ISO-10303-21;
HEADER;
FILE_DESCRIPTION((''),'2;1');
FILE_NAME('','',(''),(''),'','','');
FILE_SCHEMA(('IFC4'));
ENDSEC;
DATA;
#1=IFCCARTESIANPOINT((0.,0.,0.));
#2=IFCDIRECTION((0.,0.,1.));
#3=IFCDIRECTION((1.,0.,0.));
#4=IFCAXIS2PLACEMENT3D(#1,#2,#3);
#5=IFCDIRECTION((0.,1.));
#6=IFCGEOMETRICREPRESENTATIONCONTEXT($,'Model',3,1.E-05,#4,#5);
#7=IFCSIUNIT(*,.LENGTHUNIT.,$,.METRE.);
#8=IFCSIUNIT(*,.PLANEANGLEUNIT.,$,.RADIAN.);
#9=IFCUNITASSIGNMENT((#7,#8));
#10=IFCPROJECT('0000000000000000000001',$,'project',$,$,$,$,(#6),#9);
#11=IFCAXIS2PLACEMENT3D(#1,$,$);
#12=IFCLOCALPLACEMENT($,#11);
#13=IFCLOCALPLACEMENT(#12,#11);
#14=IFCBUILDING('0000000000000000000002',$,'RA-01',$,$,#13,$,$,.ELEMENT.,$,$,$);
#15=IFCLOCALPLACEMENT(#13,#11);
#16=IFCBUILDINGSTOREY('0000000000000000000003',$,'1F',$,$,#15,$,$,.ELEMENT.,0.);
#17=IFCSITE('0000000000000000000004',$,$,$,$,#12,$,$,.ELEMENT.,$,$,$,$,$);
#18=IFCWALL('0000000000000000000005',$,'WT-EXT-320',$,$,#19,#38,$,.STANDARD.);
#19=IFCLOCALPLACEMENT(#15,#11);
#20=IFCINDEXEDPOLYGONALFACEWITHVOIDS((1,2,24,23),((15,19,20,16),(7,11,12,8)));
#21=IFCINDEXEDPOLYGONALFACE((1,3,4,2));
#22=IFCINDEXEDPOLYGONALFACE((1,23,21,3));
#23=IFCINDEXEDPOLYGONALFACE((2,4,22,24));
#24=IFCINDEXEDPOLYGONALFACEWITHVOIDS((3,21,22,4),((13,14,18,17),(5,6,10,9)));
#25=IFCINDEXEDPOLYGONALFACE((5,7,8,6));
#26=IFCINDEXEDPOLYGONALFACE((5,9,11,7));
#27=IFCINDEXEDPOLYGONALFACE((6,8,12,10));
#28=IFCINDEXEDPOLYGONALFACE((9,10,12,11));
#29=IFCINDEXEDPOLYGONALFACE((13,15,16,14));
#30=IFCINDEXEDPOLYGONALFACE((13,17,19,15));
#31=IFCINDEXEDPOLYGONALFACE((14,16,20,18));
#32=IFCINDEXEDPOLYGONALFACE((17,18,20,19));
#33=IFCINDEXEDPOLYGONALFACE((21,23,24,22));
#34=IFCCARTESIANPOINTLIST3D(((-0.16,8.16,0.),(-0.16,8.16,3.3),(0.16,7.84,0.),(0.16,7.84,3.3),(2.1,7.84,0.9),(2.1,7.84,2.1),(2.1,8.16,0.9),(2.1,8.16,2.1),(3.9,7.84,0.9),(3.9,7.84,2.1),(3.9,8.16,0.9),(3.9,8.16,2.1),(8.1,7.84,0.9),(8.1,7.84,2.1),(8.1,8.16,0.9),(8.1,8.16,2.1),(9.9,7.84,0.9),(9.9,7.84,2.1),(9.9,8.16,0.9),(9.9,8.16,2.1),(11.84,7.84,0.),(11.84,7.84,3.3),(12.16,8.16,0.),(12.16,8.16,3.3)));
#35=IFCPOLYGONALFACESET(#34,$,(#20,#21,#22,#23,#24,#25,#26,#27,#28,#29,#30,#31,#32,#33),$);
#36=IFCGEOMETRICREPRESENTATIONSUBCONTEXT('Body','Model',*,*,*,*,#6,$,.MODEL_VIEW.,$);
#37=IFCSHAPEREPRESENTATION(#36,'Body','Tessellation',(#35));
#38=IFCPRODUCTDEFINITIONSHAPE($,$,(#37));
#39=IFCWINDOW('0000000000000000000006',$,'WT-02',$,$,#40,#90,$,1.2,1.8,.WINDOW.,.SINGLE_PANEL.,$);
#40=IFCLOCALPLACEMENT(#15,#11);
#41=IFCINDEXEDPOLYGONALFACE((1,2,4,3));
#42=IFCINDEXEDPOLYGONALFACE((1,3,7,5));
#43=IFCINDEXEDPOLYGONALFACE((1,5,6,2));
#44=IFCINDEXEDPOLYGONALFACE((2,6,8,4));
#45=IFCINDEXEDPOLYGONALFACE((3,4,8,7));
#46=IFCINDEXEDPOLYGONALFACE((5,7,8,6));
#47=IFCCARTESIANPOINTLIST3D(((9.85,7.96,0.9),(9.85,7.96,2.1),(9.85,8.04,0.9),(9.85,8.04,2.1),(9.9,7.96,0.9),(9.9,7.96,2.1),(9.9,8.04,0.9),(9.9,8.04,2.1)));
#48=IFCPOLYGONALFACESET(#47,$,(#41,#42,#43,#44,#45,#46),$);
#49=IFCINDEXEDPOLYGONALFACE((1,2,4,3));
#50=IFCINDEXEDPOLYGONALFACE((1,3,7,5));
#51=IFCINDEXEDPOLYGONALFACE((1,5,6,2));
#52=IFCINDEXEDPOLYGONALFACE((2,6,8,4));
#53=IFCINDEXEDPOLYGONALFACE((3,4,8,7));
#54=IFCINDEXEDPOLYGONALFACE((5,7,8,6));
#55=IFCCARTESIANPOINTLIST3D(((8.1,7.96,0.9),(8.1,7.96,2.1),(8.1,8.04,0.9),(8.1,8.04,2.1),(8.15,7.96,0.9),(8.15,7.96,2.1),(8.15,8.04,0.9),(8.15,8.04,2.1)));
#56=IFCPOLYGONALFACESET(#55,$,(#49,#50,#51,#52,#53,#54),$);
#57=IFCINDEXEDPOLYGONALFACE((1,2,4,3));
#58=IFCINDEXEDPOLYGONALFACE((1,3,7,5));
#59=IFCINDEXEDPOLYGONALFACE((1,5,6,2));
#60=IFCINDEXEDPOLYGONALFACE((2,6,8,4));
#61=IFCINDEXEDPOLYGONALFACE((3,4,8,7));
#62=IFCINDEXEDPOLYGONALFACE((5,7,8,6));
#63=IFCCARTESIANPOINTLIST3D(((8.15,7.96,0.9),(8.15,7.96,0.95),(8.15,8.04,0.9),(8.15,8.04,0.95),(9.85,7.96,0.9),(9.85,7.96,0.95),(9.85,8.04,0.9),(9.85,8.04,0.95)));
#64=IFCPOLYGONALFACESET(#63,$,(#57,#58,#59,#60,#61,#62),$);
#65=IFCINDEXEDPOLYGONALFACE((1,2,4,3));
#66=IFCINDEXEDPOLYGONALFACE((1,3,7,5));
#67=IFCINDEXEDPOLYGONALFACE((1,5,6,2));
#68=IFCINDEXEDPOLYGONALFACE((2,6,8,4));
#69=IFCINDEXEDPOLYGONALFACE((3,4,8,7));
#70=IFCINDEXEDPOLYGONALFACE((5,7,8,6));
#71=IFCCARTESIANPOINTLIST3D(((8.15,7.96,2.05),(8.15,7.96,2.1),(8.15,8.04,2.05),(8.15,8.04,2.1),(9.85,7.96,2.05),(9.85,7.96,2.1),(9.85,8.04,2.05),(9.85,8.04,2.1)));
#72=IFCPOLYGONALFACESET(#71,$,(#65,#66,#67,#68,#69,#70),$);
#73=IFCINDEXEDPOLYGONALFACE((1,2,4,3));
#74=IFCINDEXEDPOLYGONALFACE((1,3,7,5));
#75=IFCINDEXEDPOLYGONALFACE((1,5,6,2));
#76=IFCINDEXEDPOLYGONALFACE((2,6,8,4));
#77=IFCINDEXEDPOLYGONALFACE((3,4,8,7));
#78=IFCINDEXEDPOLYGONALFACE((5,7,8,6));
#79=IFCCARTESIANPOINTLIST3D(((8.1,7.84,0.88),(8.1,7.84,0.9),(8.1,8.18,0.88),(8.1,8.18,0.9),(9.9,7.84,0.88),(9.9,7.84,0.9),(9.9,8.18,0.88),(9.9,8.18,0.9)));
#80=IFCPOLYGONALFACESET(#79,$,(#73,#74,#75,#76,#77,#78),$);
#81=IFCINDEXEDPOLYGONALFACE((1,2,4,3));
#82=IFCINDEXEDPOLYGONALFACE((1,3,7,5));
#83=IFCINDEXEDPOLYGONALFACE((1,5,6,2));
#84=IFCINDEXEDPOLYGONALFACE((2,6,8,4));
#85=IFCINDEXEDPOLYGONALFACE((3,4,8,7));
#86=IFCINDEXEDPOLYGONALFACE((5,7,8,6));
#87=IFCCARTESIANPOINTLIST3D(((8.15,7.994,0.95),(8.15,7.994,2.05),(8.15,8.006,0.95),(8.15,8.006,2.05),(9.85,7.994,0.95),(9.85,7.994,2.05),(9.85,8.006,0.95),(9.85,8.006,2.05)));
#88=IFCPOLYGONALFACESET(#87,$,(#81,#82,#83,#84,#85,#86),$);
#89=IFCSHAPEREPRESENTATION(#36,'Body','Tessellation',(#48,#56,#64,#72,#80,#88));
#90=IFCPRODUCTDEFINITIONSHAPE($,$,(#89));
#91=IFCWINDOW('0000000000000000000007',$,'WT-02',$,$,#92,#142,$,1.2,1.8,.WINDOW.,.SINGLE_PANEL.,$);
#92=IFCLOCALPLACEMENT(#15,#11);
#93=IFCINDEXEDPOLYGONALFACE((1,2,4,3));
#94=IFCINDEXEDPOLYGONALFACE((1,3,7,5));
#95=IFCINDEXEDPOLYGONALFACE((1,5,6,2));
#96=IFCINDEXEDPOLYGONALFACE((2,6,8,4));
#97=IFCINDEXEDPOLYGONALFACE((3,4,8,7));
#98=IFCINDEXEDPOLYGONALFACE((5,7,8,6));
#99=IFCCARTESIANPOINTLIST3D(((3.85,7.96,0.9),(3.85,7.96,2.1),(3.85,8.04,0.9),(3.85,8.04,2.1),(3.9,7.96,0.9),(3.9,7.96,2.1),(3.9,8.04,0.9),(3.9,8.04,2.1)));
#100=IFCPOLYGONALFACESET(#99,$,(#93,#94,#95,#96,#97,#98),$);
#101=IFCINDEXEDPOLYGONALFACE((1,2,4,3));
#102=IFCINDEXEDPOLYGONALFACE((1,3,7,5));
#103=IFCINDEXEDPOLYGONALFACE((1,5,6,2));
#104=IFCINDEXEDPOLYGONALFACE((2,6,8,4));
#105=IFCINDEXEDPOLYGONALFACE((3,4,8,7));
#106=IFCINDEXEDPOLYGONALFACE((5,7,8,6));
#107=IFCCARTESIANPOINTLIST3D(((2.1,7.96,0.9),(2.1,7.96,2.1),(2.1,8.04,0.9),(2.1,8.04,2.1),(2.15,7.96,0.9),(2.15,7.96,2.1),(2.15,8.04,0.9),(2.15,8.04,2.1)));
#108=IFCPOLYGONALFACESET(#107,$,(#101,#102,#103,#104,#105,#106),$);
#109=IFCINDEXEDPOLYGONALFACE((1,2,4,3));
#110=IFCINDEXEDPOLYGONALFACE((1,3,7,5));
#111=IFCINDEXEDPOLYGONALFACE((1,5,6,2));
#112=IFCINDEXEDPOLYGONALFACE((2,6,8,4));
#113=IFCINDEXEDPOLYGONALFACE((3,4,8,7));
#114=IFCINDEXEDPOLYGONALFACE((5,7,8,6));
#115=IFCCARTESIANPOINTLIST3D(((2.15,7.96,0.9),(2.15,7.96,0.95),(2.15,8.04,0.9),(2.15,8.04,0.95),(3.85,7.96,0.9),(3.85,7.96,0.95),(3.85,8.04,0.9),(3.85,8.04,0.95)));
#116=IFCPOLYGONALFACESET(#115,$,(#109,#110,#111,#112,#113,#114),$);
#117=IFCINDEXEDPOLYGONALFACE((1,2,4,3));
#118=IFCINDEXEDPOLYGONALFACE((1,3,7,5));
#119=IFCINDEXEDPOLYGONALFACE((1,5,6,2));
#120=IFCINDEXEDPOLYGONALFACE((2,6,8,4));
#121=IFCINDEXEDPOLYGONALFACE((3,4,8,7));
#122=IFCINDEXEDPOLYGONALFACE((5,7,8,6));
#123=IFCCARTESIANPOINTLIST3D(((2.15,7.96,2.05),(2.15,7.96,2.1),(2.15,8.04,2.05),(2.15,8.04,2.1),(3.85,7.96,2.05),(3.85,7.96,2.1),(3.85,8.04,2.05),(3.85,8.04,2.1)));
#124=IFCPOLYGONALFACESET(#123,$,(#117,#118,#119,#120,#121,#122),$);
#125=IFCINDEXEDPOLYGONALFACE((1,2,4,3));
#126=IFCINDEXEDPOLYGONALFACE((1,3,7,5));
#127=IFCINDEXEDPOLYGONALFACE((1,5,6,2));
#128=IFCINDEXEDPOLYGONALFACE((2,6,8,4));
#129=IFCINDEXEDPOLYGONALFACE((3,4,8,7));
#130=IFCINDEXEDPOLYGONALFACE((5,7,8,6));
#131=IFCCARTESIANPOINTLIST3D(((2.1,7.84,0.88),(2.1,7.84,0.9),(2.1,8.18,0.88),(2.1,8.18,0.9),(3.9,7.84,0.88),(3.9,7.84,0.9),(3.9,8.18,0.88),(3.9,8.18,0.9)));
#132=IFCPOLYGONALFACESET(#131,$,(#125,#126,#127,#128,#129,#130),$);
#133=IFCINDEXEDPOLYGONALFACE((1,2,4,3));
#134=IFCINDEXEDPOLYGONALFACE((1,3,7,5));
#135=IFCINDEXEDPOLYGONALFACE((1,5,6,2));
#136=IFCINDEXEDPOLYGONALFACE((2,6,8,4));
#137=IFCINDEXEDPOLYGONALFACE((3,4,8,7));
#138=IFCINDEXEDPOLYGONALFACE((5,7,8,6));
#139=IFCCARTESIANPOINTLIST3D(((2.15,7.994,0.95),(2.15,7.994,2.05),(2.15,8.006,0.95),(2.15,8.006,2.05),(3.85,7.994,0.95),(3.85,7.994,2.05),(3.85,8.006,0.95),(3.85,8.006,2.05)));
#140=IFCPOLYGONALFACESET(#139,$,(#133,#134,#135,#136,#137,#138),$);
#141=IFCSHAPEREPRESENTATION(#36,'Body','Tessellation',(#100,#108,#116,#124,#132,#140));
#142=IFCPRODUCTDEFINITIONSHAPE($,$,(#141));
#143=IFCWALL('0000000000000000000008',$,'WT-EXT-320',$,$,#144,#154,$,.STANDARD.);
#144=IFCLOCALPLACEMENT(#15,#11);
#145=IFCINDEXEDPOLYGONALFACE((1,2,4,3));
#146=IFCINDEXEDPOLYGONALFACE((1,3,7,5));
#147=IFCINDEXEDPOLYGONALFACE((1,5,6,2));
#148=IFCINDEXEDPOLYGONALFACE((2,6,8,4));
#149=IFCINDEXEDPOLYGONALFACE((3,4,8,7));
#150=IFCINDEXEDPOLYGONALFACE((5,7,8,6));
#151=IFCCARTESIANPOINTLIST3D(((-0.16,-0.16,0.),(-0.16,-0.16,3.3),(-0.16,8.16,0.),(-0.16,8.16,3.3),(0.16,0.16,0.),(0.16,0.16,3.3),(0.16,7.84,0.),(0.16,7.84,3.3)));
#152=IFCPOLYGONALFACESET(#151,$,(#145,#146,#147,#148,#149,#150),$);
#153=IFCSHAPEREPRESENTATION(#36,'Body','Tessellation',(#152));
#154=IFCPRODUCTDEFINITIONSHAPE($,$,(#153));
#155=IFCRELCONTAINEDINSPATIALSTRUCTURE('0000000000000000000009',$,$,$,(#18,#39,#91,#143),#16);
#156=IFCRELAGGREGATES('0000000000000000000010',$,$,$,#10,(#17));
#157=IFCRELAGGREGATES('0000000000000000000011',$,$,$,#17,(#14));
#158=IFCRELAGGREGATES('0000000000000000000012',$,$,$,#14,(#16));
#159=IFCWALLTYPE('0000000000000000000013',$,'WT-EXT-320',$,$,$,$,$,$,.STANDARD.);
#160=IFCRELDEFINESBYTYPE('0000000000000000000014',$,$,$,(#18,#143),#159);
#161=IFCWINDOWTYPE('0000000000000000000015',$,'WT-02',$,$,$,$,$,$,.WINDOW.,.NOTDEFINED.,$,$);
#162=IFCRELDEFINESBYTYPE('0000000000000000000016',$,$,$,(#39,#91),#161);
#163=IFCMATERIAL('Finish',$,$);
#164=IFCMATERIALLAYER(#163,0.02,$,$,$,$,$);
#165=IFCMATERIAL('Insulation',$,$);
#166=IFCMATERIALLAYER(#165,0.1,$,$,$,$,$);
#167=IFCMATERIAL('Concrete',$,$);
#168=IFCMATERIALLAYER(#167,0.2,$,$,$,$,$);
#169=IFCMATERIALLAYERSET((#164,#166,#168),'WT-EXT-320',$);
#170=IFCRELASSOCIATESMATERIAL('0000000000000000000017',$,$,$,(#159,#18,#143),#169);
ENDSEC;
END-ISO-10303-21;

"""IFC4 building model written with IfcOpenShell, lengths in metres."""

from ifc_helpers import new_model, si_unit, direction, frame, frame_2d, origin, origin_with_axes, place, context, subcontext, project, spatial, polyline, rectangle, outline, extrude, material, layer, layer_set, layer_usage, type_object, element, fill, save


model = new_model("IFC4")

# Units and contexts
model_context = context("Model", 3, precision=1e-05, world=origin_with_axes(), true_north=direction((0.0, 1.0)))
body_context = subcontext(model_context, "Body", "Model", "MODEL_VIEW")
ifc_project = project(units=[si_unit("LENGTHUNIT", "METRE"), si_unit("PLANEANGLEUNIT", "RADIAN")], contexts=[model_context])

# Site, building, storey
site_placement = place(None, origin())
site = spatial("IfcSite", under=ifc_project, at=site_placement, CompositionType="ELEMENT")
building_placement = place(site_placement, origin())
building = spatial("IfcBuilding", under=site, at=building_placement, Name="RA-01", CompositionType="ELEMENT")
storey_placement = place(building_placement, origin())
storey = spatial("IfcBuildingStorey", under=building, at=storey_placement, Name="1F", CompositionType="ELEMENT", Elevation=0.0)

# Shared definitions
ifc_material_1 = material(Name="Concrete")

# Shared definitions
ifc_material_2 = material(Name="Finish")
ifc_layer_1 = layer(ifc_material_2, 0.02)
ifc_material_3 = material(Name="Insulation")
ifc_layer_2 = layer(ifc_material_3, 0.1)
ifc_layer_3 = layer(ifc_material_1, 0.2)
ifc_layer_set_1 = layer_set([ifc_layer_1, ifc_layer_2, ifc_layer_3], Name="WT-EXT-320")
ifc_layer_usage_1 = layer_usage(ifc_layer_set_1, "AXIS2", "NEGATIVE", 0.16)
wall_type_1 = type_object("IfcWallType", Name="WT-EXT-320", PredefinedType="STANDARD", material=ifc_layer_set_1)

# Wall, openings, windows
wall_1_placement = place(storey_placement, frame((12.0, 8.0, 0.0), z_axis=(0.0, 0.0, 1.0), x_axis=(-1.0, 0.0, 0.0)))
wall_1 = element("IfcWall", 1, at=wall_1_placement, inside=storey, type_object=wall_type_1, material=ifc_layer_usage_1, Name="WT-EXT-320", PredefinedType="STANDARD", context=body_context, shape_type="SweptSolid", body=[
    extrude(outline(polyline([(-0.16, -0.16), (12.16, -0.16), (11.84, 0.16), (0.16, 0.16), (-0.16, -0.16)])), origin(), (0.0, 0.0, 1.0), 3.3),
])
opening_1_placement = place(wall_1_placement, frame((2.1, 0.0, 0.9)))
opening_1 = element("IfcOpeningElement", 2, at=opening_1_placement, cuts=wall_1, PredefinedType="OPENING", context=body_context, shape_type="SweptSolid", body=[
    extrude(rectangle(XDim=1.8, YDim=0.42, at=frame_2d((0.9, 0.0))), origin(), (0.0, 0.0, 1.0), 1.2),
])
opening_2_placement = place(wall_1_placement, frame((8.1, 0.0, 0.9)))
opening_2 = element("IfcOpeningElement", 3, at=opening_2_placement, cuts=wall_1, PredefinedType="OPENING", context=body_context, shape_type="SweptSolid", body=[
    extrude(rectangle(XDim=1.8, YDim=0.42, at=frame_2d((0.9, 0.0))), origin(), (0.0, 0.0, 1.0), 1.2),
])
window_type_1 = type_object("IfcWindowType", Name="WT-02", PartitioningType="NOTDEFINED", PredefinedType="WINDOW")
window_1_placement = place(opening_1_placement, origin())
window_1 = element("IfcWindow", 4, at=window_1_placement, inside=storey, type_object=window_type_1, Name="WT-02", OverallHeight=1.2, OverallWidth=1.8, PartitioningType="SINGLE_PANEL", PredefinedType="WINDOW", context=body_context, shape_type="SweptSolid", body=[
    extrude(outline(polyline([(0.0, -0.04), (0.05, -0.04), (0.05, 0.04), (0.0, 0.04), (0.0, -0.04)])), origin(), (0.0, 0.0, 1.0), 1.2),
    extrude(outline(polyline([(1.75, -0.04), (1.8, -0.04), (1.8, 0.04), (1.75, 0.04), (1.75, -0.04)])), origin(), (0.0, 0.0, 1.0), 1.2),
    extrude(outline(polyline([(0.05, -0.04), (1.75, -0.04), (1.75, 0.04), (0.05, 0.04), (0.05, -0.04)])), origin(), (0.0, 0.0, 1.0), 0.05),
    extrude(outline(polyline([(0.05, -0.04), (1.75, -0.04), (1.75, 0.04), (0.05, 0.04), (0.05, -0.04)])), frame((0.0, 0.0, 1.15)), (0.0, 0.0, 1.0), 0.05),
    extrude(outline(polyline([(0.0, -0.18), (1.8, -0.18), (1.8, 0.16), (0.0, 0.16), (0.0, -0.18)])), frame((0.0, 0.0, -0.02)), (0.0, 0.0, 1.0), 0.02),
    extrude(outline(polyline([(0.05, -0.006), (1.75, -0.006), (1.75, 0.006), (0.05, 0.006), (0.05, -0.006)])), frame((0.0, 0.0, 0.05)), (0.0, 0.0, 1.0), 1.1),
])
fill(opening_1, window_1)
window_2_placement = place(opening_2_placement, origin())
window_2 = element("IfcWindow", 5, at=window_2_placement, inside=storey, type_object=window_type_1, Name="WT-02", OverallHeight=1.2, OverallWidth=1.8, PartitioningType="SINGLE_PANEL", PredefinedType="WINDOW", context=body_context, shape_type="SweptSolid", body=[
    extrude(outline(polyline([(0.0, -0.04), (0.05, -0.04), (0.05, 0.04), (0.0, 0.04), (0.0, -0.04)])), origin(), (0.0, 0.0, 1.0), 1.2),
    extrude(outline(polyline([(1.75, -0.04), (1.8, -0.04), (1.8, 0.04), (1.75, 0.04), (1.75, -0.04)])), origin(), (0.0, 0.0, 1.0), 1.2),
    extrude(outline(polyline([(0.05, -0.04), (1.75, -0.04), (1.75, 0.04), (0.05, 0.04), (0.05, -0.04)])), origin(), (0.0, 0.0, 1.0), 0.05),
    extrude(outline(polyline([(0.05, -0.04), (1.75, -0.04), (1.75, 0.04), (0.05, 0.04), (0.05, -0.04)])), frame((0.0, 0.0, 1.15)), (0.0, 0.0, 1.0), 0.05),
    extrude(outline(polyline([(0.0, -0.18), (1.8, -0.18), (1.8, 0.16), (0.0, 0.16), (0.0, -0.18)])), frame((0.0, 0.0, -0.02)), (0.0, 0.0, 1.0), 0.02),
    extrude(outline(polyline([(0.05, -0.006), (1.75, -0.006), (1.75, 0.006), (0.05, 0.006), (0.05, -0.006)])), frame((0.0, 0.0, 0.05)), (0.0, 0.0, 1.0), 1.1),
])
fill(opening_2, window_2)

# Wall
wall_2_placement = place(storey_placement, frame((0.0, 8.0, 0.0), z_axis=(0.0, 0.0, 1.0), x_axis=(0.0, -1.0, 0.0)))
element("IfcWall", 6, at=wall_2_placement, inside=storey, type_object=wall_type_1, material=ifc_layer_usage_1, Name="WT-EXT-320", PredefinedType="STANDARD", context=body_context, shape_type="SweptSolid", body=[
    extrude(outline(polyline([(-0.16, -0.16), (8.16, -0.16), (7.84, 0.16), (0.16, 0.16), (-0.16, -0.16)])), origin(), (0.0, 0.0, 1.0), 3.3),
])

save(model, "model.ifc")
